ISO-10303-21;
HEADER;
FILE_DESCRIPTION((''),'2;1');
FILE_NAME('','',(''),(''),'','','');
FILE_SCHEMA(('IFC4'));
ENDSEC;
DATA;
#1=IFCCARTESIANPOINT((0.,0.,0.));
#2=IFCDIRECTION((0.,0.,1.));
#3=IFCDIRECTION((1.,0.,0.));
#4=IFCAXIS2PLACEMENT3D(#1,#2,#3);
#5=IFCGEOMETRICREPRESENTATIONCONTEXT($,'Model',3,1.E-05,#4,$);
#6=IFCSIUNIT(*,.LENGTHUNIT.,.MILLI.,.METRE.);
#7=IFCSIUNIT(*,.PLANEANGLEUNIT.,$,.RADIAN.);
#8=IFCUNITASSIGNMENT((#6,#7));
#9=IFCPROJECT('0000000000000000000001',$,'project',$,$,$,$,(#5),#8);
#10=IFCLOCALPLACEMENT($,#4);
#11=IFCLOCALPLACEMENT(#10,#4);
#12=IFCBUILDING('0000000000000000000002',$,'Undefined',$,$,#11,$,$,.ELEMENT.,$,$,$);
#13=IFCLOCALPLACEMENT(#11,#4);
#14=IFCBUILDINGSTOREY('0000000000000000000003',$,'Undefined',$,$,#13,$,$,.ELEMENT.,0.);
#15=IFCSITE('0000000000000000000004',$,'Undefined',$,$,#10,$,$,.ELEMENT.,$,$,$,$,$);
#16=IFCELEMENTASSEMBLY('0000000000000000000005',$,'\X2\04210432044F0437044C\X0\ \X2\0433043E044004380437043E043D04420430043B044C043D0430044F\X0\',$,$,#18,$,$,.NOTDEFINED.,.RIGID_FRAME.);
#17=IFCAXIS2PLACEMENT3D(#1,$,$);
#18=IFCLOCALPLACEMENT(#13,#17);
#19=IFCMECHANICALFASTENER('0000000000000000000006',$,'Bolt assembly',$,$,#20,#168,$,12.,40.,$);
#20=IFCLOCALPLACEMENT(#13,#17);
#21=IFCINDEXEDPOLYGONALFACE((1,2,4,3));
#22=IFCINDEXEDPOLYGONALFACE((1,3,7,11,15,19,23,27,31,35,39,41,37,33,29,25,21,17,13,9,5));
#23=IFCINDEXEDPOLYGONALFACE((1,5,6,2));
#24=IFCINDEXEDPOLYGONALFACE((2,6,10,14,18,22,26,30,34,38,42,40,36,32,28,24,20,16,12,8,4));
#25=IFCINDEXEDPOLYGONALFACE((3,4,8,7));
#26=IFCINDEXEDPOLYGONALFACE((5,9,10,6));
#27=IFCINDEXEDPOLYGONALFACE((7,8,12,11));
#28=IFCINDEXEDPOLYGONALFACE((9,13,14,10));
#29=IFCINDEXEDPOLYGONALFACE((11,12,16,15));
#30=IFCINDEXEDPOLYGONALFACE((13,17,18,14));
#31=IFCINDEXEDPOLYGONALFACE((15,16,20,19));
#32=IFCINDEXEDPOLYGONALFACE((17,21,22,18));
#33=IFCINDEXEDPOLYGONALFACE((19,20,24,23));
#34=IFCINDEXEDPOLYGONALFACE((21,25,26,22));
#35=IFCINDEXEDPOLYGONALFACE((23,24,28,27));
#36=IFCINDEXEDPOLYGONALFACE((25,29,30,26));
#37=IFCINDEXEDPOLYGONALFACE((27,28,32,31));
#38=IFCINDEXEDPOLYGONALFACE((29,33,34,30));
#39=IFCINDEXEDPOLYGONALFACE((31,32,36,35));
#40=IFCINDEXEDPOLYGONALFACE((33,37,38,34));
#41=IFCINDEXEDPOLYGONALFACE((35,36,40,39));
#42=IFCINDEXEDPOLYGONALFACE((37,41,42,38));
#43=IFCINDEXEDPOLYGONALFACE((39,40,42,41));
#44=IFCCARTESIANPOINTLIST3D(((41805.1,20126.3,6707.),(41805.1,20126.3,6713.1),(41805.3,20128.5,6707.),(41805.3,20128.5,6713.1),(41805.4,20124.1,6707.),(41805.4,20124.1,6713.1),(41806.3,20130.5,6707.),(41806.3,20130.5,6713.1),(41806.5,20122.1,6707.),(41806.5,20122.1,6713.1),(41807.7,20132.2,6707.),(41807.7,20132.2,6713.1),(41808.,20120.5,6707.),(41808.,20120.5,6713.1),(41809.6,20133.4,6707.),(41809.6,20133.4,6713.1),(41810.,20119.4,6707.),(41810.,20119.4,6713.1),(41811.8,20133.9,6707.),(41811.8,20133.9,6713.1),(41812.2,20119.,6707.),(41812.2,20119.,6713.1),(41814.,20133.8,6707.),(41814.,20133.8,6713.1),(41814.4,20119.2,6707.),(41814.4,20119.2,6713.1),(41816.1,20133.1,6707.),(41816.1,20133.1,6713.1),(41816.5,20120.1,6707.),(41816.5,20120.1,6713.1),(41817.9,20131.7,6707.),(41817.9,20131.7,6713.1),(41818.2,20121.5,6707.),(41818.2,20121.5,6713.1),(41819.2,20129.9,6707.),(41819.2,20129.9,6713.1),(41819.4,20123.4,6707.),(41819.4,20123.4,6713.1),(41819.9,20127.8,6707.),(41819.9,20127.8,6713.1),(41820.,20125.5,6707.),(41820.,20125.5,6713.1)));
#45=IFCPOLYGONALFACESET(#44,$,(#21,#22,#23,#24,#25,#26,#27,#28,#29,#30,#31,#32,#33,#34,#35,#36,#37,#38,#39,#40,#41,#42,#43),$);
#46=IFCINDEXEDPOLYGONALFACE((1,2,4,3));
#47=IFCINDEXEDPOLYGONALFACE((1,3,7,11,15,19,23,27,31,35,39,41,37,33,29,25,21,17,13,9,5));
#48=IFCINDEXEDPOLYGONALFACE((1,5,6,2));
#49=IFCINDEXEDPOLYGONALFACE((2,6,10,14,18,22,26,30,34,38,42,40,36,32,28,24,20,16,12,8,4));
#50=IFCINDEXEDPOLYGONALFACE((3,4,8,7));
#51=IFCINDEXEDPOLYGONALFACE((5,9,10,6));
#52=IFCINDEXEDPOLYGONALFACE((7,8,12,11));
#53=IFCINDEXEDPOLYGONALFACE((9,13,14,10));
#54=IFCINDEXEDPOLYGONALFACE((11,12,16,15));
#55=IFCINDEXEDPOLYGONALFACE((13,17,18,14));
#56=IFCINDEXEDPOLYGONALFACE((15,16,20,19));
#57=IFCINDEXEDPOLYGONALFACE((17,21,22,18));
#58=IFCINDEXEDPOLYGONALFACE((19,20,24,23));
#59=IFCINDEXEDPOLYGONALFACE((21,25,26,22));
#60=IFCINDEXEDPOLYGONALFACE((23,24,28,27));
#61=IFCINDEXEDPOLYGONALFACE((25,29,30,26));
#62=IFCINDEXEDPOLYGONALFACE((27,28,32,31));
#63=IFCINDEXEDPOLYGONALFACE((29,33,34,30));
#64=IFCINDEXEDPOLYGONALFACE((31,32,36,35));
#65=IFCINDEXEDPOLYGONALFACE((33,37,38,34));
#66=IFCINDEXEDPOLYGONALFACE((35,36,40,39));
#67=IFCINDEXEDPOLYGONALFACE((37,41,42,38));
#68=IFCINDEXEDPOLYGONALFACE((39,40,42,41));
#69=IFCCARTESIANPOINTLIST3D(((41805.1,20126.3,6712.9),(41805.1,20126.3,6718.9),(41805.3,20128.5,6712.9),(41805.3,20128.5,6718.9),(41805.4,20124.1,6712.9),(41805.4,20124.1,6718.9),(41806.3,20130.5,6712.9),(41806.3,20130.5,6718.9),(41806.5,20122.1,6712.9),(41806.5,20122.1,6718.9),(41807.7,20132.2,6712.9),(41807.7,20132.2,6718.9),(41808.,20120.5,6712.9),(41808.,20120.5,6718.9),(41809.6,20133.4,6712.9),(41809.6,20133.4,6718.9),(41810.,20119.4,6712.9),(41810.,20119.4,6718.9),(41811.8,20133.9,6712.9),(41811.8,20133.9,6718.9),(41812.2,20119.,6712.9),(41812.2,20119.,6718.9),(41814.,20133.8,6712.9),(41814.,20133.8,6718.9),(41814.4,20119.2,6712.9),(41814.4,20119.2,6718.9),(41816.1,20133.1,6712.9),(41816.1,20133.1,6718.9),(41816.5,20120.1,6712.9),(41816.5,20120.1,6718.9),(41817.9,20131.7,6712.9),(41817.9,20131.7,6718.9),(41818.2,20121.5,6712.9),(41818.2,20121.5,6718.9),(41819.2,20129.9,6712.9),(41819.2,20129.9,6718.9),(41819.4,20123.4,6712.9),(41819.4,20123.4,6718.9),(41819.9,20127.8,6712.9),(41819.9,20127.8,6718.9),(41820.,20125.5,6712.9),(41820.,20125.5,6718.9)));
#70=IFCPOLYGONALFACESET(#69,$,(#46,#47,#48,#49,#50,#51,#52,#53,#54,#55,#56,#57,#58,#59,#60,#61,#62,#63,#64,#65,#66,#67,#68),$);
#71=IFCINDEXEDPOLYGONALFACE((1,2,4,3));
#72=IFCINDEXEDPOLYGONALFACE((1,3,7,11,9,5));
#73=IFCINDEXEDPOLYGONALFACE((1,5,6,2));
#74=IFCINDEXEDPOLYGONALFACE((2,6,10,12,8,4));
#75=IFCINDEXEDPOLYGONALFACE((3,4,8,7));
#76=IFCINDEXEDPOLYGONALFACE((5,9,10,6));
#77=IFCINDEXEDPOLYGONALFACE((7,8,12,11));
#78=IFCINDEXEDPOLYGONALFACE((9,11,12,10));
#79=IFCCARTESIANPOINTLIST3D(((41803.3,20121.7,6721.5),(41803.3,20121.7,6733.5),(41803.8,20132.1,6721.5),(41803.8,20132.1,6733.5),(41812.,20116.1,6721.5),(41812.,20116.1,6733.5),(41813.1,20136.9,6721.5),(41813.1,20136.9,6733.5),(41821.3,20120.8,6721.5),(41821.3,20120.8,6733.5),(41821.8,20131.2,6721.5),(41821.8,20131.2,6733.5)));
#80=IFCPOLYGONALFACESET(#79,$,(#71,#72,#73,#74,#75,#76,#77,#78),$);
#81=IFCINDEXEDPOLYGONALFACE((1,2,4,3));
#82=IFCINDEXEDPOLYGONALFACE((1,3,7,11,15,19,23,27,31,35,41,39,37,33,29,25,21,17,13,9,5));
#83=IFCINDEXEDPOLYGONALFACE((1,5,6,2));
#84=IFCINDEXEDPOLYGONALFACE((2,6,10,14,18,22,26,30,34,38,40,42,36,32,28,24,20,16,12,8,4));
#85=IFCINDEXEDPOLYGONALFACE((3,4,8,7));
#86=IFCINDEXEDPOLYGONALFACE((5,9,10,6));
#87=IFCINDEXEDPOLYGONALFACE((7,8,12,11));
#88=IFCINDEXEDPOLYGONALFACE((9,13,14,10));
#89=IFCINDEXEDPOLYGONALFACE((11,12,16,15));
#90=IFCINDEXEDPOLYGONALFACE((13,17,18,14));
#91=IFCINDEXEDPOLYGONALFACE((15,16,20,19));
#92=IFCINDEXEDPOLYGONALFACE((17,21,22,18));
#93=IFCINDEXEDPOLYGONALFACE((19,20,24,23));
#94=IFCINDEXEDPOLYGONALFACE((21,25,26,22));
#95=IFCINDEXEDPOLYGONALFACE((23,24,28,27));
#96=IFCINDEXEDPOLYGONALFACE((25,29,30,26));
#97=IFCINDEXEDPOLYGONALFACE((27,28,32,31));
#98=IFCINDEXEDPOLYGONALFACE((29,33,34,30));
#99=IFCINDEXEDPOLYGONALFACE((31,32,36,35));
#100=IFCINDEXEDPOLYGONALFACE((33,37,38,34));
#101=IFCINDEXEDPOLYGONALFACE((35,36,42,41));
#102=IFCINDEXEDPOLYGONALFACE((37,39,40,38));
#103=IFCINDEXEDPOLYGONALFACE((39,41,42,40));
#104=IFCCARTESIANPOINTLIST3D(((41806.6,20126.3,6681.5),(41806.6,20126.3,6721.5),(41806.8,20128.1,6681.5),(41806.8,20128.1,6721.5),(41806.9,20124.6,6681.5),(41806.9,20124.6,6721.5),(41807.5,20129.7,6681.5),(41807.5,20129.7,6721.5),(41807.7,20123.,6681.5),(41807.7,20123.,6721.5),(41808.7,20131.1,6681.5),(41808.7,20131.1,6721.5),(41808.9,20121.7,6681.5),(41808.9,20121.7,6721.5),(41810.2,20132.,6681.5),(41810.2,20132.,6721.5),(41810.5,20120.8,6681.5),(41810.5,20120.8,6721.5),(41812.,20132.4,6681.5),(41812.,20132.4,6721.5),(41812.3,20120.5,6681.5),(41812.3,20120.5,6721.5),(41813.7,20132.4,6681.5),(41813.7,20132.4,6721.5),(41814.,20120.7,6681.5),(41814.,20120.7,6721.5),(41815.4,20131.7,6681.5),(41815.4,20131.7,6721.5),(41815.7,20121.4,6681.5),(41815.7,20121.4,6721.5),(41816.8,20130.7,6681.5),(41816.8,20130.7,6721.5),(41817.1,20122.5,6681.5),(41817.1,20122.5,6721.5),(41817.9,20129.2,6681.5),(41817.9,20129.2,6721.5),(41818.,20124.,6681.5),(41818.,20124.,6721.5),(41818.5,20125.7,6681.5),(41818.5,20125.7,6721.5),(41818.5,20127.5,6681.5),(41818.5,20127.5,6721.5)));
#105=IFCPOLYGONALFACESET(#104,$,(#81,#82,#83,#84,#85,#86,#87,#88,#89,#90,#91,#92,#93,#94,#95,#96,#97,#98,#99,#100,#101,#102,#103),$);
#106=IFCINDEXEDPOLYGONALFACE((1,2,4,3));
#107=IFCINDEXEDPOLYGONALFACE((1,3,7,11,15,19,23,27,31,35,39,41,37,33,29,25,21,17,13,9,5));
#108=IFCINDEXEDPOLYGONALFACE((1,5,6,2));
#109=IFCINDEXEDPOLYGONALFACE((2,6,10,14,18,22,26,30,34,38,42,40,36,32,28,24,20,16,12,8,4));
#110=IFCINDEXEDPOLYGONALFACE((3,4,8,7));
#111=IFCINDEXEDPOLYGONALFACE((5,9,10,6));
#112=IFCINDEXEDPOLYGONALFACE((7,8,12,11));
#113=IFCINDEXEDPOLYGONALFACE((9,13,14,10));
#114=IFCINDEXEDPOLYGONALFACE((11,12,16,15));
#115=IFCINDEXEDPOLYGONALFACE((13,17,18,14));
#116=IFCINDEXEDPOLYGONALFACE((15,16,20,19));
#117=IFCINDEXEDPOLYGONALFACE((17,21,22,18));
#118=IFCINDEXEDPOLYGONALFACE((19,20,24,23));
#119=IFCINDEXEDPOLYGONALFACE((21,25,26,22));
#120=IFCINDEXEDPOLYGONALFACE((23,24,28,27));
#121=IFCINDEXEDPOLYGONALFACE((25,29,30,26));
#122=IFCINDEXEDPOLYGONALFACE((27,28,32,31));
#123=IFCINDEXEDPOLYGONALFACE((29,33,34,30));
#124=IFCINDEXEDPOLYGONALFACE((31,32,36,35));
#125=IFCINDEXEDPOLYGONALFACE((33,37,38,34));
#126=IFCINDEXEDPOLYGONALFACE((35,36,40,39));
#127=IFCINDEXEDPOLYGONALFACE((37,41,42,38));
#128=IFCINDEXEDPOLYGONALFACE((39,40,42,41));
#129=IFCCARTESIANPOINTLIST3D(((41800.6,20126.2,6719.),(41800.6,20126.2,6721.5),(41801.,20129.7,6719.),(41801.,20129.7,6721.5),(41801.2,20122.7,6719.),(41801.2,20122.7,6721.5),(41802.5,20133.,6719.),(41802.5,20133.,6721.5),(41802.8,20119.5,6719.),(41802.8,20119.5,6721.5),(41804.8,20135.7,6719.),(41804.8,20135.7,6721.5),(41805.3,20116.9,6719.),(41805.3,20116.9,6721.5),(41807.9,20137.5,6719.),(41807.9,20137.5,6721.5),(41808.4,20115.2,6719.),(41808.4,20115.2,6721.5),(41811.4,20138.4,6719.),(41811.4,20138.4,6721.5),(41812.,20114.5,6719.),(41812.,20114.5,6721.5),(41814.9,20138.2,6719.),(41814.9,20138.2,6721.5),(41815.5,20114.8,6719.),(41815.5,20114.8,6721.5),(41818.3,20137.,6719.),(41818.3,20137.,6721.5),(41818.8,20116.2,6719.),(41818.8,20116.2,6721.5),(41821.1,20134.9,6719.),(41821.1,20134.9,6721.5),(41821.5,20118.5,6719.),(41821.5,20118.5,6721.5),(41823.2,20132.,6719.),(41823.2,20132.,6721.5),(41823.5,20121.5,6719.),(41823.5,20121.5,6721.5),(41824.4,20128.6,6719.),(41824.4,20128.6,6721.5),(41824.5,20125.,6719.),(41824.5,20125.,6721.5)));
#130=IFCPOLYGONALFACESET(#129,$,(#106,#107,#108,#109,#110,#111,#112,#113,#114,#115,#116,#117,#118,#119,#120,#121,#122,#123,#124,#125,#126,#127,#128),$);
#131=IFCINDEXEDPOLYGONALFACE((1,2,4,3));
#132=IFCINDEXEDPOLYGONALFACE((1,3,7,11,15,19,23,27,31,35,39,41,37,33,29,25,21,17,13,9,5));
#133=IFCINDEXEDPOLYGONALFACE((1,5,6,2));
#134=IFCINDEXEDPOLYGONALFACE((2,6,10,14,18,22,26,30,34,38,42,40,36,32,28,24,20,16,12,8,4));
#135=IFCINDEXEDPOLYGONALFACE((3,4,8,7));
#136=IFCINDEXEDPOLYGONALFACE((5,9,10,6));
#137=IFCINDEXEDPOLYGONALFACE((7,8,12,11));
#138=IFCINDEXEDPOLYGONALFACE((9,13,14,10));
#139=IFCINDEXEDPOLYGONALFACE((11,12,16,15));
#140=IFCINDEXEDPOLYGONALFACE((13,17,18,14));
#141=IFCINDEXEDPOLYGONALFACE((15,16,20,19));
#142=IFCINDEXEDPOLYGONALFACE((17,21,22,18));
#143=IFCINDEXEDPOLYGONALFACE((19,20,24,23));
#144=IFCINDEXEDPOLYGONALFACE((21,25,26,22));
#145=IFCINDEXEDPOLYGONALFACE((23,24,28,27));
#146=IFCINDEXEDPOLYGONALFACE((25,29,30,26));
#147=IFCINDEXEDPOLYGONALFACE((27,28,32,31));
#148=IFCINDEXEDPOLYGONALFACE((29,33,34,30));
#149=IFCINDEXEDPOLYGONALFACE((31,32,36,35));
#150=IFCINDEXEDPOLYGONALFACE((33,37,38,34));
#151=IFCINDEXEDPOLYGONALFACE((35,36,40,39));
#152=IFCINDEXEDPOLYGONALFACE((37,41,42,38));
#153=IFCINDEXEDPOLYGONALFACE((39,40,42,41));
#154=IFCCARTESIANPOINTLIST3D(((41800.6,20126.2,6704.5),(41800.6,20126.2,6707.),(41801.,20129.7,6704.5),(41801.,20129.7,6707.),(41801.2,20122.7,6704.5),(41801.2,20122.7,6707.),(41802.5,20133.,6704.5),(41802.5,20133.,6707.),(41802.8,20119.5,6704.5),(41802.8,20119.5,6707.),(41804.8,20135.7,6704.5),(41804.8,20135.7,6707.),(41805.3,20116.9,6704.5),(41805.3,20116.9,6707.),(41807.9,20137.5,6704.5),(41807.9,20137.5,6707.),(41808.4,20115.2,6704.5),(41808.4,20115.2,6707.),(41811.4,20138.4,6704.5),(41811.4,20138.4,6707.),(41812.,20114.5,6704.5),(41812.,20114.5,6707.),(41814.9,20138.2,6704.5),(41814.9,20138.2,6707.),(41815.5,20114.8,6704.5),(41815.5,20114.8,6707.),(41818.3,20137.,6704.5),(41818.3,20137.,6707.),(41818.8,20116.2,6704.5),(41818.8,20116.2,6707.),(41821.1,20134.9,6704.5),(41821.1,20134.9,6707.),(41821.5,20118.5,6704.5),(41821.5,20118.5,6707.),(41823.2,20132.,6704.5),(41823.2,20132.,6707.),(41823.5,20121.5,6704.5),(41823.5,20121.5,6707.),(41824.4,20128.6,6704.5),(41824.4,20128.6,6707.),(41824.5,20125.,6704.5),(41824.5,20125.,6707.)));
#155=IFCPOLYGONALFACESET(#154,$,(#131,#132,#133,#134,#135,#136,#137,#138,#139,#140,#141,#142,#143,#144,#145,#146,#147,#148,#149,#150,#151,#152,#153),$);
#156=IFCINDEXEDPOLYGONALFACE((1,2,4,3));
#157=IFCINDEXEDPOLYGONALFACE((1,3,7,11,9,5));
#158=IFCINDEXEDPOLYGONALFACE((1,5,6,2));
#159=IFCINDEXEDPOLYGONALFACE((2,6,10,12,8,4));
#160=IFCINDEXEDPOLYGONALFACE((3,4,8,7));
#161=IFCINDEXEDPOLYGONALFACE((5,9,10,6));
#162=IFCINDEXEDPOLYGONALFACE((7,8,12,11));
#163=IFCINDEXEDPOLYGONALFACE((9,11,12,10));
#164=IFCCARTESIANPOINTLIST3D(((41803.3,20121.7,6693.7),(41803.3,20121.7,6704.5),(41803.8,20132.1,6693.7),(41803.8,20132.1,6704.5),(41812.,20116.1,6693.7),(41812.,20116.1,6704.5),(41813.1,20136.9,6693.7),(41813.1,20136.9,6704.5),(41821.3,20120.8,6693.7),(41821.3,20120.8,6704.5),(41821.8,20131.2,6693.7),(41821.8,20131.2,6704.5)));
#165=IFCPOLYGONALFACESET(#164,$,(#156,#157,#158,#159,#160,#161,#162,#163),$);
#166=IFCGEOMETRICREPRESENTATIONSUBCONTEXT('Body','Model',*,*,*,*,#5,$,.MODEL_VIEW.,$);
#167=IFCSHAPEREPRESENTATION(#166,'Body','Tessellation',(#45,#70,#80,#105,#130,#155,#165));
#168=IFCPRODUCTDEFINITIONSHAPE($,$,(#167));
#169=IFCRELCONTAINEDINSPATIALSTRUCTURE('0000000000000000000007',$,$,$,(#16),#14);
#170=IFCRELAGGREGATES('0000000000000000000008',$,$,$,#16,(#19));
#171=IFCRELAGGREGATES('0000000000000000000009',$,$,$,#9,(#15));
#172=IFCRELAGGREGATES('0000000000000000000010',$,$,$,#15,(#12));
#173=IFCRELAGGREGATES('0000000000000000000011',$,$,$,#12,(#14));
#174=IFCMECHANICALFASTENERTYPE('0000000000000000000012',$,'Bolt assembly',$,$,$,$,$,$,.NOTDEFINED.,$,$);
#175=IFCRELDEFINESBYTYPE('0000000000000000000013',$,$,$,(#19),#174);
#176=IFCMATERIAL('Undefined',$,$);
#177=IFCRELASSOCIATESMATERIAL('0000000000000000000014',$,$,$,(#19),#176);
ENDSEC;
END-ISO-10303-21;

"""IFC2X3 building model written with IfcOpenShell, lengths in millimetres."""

from ifc_helpers import new_model, si_unit, frame, origin_with_axes, origin_2d_with_axis, place, context, subcontext, project, spatial, polyline, circle, outline, extrude, source, transform, mapped, material, type_object, element, aggregate, save


model = new_model("IFC2X3")

# Units and contexts
model_context = context("Model", 3, precision=1e-05, world=origin_with_axes())
body_context = subcontext(model_context, "Body", "Model", "MODEL_VIEW")
ifc_project = project(units=[si_unit("LENGTHUNIT", "METRE", prefix="MILLI"), si_unit("PLANEANGLEUNIT", "RADIAN")], contexts=[model_context])

# Site, building, storey
site_placement = place(None, origin_with_axes())
site = spatial("IfcSite", under=ifc_project, at=site_placement, Name="Undefined", CompositionType="ELEMENT")
building_placement = place(site_placement, origin_with_axes())
building = spatial("IfcBuilding", under=site, at=building_placement, Name="Undefined", CompositionType="ELEMENT")
storey_placement = place(building_placement, origin_with_axes())
storey = spatial("IfcBuildingStorey", under=building, at=storey_placement, Name="Undefined", CompositionType="ELEMENT", Elevation=0.0)

# Element assembly
assembly_1_placement = place(storey_placement, origin_with_axes())
assembly_1 = element("IfcElementAssembly", 1, at=assembly_1_placement, inside=storey, Name="Связь горизонтальная", AssemblyPlace="NOTDEFINED", PredefinedType="RIGID_FRAME")

# Mechanical fastener
ifc_material_1 = material(Name="Undefined")
mechanical_fastener_type = type_object("IfcMechanicalFastenerType", Name="Bolt assembly")
shared_shape_1 = source(origin_with_axes(), body_context, "Body", "SweptSolid", [
    extrude(circle(Radius=7.5, at=origin_2d_with_axis()), frame((0.0, -0.1, 0.0), z_axis=(0.0, 1.0, 0.0), x_axis=(1.0, 0.0, 0.0)), (0.0, 0.0, 1.0), 6.1),
    extrude(circle(Radius=7.5, at=origin_2d_with_axis()), frame((0.0, -5.9, 0.0), z_axis=(0.0, 1.0, 0.0), x_axis=(1.0, 0.0, 0.0)), (0.0, 0.0, 1.0), 6.0),
    extrude(outline(polyline([(10.4, 0.0), (5.2, 9.0), (-5.2, 9.0), (-10.4, 0.0), (-5.2, -9.0), (5.2, -9.0), (10.4, 0.0)])), frame((0.0, -20.5, 0.0), z_axis=(0.0, 1.0, 0.0), x_axis=(1.0, 0.0, 0.0)), (0.0, 0.0, 1.0), 12.0),
    extrude(circle(Radius=6.0, at=origin_2d_with_axis()), frame((0.0, -8.5, 0.0), z_axis=(0.0, 1.0, 0.0), x_axis=(1.0, 0.0, 0.0)), (0.0, 0.0, 1.0), 40.0),
    extrude(circle(Radius=12.0, at=origin_2d_with_axis()), frame((0.0, -8.5, 0.0), z_axis=(0.0, 1.0, 0.0), x_axis=(1.0, 0.0, 0.0)), (0.0, 0.0, 1.0), 2.5),
    extrude(circle(Radius=12.0, at=origin_2d_with_axis()), frame((0.0, 6.0, 0.0), z_axis=(0.0, 1.0, 0.0), x_axis=(1.0, 0.0, 0.0)), (0.0, 0.0, 1.0), 2.5),
    extrude(outline(polyline([(10.4, 0.0), (5.2, 9.0), (-5.2, 9.0), (-10.4, 0.0), (-5.2, -9.0), (5.2, -9.0), (10.4, 0.0)])), frame((0.0, 8.5, 0.0), z_axis=(0.0, 1.0, 0.0), x_axis=(1.0, 0.0, 0.0)), (0.0, 0.0, 1.0), 10.8),
])
mechanical_fastener_1_placement = place(assembly_1_placement, frame((41812.6, 20126.5, 6713.0), z_axis=(-0.542525, -0.840039, 0.0), x_axis=(-0.840039, 0.542525, 0.0)))
mechanical_fastener_1 = element("IfcMechanicalFastener", 2, at=mechanical_fastener_1_placement, type_object=mechanical_fastener_type, material=ifc_material_1, Name="Bolt assembly", NominalDiameter=12.0, NominalLength=40.0, context=body_context, shape_type="MappedRepresentation", body=[
    mapped(shared_shape_1, transform((0.0, 0.0, 0.0))),
])
aggregate(assembly_1, [mechanical_fastener_1])

save(model, "model.ifc")
